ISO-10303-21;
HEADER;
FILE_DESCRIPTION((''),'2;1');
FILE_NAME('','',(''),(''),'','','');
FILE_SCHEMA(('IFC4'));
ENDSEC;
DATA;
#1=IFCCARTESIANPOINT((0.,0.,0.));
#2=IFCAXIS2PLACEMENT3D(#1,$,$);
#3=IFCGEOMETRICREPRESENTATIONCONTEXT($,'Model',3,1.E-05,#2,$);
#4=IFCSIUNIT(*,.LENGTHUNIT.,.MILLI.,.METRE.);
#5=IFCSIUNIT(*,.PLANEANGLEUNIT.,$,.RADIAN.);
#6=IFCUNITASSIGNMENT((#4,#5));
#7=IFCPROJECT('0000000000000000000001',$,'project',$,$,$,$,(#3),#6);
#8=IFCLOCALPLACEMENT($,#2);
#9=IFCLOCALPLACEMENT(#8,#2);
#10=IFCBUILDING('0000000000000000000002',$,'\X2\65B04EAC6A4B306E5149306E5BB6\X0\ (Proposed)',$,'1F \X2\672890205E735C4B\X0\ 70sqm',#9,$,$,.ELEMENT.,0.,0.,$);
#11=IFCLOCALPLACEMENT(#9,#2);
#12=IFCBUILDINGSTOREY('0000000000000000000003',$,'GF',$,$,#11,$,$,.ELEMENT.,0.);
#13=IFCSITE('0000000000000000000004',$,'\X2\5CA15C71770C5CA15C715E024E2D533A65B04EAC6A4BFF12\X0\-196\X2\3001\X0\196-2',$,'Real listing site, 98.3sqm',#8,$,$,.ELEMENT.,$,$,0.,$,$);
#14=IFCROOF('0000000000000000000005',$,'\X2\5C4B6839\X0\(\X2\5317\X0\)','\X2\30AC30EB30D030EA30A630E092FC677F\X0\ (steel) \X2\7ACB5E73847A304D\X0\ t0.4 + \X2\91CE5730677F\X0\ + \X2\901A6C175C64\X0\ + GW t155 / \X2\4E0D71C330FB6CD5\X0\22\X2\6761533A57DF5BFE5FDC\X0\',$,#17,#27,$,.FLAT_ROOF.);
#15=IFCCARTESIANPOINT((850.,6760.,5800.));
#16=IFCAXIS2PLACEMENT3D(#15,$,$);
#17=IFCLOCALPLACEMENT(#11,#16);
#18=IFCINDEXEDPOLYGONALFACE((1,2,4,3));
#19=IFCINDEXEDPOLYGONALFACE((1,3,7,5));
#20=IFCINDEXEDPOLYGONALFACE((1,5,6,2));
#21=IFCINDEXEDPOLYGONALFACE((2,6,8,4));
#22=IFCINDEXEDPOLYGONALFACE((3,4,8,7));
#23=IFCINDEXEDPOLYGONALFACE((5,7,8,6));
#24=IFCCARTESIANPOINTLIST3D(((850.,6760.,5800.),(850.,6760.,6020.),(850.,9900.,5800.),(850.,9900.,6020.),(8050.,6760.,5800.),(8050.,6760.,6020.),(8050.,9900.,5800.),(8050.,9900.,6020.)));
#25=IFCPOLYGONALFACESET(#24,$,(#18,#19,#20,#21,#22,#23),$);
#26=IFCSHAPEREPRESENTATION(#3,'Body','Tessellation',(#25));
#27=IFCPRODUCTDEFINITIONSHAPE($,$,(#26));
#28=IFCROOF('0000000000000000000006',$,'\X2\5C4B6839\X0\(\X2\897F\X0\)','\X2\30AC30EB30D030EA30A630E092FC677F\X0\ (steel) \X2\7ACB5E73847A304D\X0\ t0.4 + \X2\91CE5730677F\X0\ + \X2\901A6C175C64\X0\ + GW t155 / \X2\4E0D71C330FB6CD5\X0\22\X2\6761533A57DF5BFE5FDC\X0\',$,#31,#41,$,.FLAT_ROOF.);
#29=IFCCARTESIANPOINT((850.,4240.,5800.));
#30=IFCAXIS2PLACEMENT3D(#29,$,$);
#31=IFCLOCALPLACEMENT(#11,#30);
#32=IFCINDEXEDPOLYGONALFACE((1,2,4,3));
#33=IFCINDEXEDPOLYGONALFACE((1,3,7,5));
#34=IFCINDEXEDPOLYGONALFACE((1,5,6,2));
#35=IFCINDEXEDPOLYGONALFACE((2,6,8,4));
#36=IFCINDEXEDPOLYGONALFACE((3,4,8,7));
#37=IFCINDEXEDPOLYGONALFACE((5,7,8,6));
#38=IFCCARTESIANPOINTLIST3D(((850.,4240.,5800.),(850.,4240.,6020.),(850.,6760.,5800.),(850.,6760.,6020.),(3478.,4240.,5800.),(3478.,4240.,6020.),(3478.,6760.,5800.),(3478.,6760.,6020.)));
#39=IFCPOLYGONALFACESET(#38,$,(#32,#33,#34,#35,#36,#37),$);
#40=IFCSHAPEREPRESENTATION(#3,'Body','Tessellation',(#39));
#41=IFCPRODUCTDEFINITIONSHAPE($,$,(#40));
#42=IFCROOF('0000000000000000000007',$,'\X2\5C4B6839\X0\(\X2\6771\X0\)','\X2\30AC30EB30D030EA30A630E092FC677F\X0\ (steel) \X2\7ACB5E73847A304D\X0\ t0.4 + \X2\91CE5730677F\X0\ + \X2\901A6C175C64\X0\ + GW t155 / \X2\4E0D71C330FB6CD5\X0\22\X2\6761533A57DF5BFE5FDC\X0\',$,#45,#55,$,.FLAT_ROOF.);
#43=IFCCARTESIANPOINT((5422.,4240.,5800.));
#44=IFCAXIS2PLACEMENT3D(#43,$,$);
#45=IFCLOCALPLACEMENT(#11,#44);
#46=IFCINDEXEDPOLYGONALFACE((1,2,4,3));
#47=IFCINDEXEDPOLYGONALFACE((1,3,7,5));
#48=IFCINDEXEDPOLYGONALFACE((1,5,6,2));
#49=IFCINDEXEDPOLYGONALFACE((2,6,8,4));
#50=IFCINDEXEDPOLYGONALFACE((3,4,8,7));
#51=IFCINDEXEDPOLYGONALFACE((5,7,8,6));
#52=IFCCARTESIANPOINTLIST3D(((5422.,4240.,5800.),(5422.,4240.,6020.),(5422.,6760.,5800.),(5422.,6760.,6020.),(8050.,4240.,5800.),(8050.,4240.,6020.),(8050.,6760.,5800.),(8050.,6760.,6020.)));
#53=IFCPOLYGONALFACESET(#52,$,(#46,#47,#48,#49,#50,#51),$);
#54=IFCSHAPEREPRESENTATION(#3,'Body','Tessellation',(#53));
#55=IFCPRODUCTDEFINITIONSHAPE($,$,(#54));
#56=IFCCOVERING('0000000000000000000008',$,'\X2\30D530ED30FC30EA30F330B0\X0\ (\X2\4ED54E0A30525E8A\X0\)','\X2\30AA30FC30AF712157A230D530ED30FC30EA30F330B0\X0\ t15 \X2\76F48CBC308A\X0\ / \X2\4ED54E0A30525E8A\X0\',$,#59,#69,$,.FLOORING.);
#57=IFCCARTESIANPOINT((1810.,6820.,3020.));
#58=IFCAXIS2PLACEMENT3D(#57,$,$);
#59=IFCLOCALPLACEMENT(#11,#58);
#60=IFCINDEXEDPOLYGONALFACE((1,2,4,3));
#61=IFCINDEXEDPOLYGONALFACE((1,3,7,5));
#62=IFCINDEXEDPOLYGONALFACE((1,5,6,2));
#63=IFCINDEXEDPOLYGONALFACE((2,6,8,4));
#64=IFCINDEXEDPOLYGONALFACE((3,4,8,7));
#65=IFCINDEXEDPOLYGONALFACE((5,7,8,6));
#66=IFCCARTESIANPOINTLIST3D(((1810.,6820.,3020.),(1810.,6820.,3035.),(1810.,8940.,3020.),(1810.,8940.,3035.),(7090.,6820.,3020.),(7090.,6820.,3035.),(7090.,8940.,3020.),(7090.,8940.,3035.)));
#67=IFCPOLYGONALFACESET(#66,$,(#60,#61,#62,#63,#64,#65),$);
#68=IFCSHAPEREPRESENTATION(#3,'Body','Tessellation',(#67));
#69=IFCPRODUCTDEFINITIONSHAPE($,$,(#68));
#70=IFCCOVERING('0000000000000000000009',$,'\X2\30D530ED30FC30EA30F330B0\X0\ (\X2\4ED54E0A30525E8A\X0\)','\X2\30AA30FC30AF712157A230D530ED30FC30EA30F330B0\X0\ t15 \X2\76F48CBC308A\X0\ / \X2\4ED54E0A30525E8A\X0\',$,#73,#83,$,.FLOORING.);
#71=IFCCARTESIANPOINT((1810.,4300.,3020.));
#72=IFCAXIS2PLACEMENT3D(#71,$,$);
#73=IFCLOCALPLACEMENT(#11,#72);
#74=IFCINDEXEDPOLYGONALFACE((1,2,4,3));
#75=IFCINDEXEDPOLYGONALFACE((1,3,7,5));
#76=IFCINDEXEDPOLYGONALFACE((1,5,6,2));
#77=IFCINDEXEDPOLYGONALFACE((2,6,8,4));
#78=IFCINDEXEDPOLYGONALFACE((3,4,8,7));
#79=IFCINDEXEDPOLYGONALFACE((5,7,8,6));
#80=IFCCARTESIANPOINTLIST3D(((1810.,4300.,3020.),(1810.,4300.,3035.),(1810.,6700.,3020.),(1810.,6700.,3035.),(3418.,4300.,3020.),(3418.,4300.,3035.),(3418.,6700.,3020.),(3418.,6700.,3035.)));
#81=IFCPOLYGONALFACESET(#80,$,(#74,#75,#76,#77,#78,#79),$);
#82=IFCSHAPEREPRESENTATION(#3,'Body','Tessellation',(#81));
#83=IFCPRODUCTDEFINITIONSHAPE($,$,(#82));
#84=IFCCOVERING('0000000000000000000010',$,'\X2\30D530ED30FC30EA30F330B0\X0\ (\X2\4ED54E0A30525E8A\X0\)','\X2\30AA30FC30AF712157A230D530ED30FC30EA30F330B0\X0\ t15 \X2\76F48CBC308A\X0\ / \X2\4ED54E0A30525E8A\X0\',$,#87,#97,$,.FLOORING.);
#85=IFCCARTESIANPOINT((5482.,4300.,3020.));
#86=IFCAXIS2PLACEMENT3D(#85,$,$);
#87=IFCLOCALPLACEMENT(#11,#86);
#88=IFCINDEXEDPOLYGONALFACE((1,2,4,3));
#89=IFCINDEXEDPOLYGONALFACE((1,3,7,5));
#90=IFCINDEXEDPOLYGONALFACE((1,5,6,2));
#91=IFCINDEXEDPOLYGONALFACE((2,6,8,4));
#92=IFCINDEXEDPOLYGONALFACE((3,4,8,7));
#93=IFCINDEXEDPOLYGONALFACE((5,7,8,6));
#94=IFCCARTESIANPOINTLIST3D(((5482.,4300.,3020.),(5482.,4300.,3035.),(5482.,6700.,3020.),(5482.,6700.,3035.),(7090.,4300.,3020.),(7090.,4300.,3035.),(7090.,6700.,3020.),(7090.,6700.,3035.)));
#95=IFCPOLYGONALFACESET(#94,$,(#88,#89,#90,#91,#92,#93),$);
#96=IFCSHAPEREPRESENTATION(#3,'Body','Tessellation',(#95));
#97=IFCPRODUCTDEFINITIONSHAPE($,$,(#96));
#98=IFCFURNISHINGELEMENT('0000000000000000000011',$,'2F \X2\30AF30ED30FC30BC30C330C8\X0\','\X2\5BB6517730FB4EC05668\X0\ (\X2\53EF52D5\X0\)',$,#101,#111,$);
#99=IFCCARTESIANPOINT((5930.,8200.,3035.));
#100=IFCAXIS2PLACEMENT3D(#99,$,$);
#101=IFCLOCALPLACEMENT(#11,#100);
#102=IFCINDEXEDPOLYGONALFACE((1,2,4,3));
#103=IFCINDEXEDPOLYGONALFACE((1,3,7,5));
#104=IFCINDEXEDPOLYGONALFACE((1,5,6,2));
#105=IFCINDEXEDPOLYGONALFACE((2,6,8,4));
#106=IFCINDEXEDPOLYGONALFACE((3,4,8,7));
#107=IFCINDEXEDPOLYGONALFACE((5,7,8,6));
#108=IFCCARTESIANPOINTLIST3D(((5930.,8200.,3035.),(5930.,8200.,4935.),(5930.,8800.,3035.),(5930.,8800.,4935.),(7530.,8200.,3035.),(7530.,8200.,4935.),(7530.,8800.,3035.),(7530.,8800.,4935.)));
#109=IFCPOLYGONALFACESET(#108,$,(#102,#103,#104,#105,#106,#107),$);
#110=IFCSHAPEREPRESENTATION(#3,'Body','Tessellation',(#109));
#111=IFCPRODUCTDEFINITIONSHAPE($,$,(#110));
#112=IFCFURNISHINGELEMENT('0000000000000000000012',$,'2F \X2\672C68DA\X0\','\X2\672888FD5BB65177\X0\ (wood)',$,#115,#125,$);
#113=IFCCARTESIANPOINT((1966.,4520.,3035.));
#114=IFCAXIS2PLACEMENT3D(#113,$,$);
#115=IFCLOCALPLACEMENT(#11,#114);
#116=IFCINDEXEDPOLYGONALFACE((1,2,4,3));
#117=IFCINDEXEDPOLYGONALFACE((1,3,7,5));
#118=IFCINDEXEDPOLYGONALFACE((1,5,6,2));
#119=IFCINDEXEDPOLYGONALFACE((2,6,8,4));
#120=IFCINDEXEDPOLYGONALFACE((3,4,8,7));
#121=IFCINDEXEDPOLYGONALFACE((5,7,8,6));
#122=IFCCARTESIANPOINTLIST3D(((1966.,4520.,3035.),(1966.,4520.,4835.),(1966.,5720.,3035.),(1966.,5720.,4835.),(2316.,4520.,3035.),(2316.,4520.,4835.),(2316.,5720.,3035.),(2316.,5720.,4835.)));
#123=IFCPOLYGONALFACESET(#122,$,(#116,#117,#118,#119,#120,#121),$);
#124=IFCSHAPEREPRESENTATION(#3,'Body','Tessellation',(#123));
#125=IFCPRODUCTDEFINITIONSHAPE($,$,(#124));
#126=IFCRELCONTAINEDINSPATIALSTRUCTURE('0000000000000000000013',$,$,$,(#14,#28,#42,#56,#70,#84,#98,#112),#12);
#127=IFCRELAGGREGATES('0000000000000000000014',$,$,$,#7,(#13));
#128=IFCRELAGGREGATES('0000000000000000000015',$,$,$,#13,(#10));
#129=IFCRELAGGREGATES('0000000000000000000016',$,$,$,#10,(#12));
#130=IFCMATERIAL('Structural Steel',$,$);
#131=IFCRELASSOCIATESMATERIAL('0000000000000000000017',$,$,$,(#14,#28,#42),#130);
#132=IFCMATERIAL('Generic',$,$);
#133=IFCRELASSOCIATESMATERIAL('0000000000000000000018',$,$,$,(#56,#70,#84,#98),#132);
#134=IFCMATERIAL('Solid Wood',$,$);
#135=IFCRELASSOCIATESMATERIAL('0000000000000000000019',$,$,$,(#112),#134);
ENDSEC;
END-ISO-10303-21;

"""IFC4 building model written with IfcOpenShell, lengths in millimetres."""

from ifc_helpers import new_model, si_unit, frame, frame_2d, origin, place, context, project, spatial, rectangle, extrude, material, element, save


model = new_model("IFC4")

# Units and contexts
model_context = context("Model", 3, precision=1e-05, world=origin())
ifc_project = project(units=[si_unit("LENGTHUNIT", "METRE", prefix="MILLI"), si_unit("PLANEANGLEUNIT", "RADIAN")], contexts=[model_context])

# Site, building, storey
site_placement = place(None, origin())
site = spatial("IfcSite", under=ifc_project, at=site_placement, Name="岡山県岡山市中区新京橋２-196、196-2", ObjectType="Real listing site, 98.3sqm", CompositionType="ELEMENT", RefElevation=0.0)
building_placement = place(site_placement, origin())
building = spatial("IfcBuilding", under=site, at=building_placement, Name="新京橋の光の家 (Proposed)", ObjectType="1F 木造平屋 70sqm", CompositionType="ELEMENT", ElevationOfRefHeight=0.0, ElevationOfTerrain=0.0)
storey_placement = place(building_placement, origin())
storey = spatial("IfcBuildingStorey", under=building, at=storey_placement, Name="GF", CompositionType="ELEMENT", Elevation=0.0)

# Shared definitions
ifc_material_1 = material(Name="Solid Wood")

# Shared definitions
ifc_material_2 = material(Name="Generic")

# Roofs
ifc_material_3 = material(Name="Structural Steel")
for number, where, name in (
    (1, (850.0, 6760.0, 5800.0), "屋根(北)"),
):
    element("IfcRoof", number, at=place(storey_placement, frame(where)), inside=storey, material=ifc_material_3, Name=name, Description="ガルバリウム鋼板 (steel) 立平葺き t0.4 + 野地板 + 通気層 + GW t155 / 不燃・法22条区域対応", PredefinedType="FLAT_ROOF", context=model_context, shape_type="SweptSolid", body=[
        extrude(rectangle(XDim=7200.0, YDim=3140.0, at=frame_2d((3600.0, 1570.0))), frame((850.0, 6760.0, 5800.0)), (0.0, 0.0, 1.0), 220.0),
    ])
roof_1_placement = place(storey_placement, frame((850.0, 4240.0, 5800.0)))
element("IfcRoof", 2, at=roof_1_placement, inside=storey, material=ifc_material_3, Name="屋根(西)", Description="ガルバリウム鋼板 (steel) 立平葺き t0.4 + 野地板 + 通気層 + GW t155 / 不燃・法22条区域対応", PredefinedType="FLAT_ROOF", context=model_context, shape_type="SweptSolid", body=[
    extrude(rectangle(XDim=2628.0, YDim=2520.0, at=frame_2d((1314.0, 1260.0))), frame((850.0, 4240.0, 5800.0)), (0.0, 0.0, 1.0), 220.0),
])
roof_2_placement = place(storey_placement, frame((5422.0, 4240.0, 5800.0)))
element("IfcRoof", 3, at=roof_2_placement, inside=storey, material=ifc_material_3, Name="屋根(東)", Description="ガルバリウム鋼板 (steel) 立平葺き t0.4 + 野地板 + 通気層 + GW t155 / 不燃・法22条区域対応", PredefinedType="FLAT_ROOF", context=model_context, shape_type="SweptSolid", body=[
    extrude(rectangle(XDim=2628.0, YDim=2520.0, at=frame_2d((1314.0, 1260.0))), frame((5422.0, 4240.0, 5800.0)), (0.0, 0.0, 1.0), 220.0),
])

# Coverings
covering_1_placement = place(storey_placement, frame((1810.0, 6820.0, 3020.0)))
element("IfcCovering", 4, at=covering_1_placement, inside=storey, material=ifc_material_2, Name="フローリング (仕上げ床)", Description="オーク無垢フローリング t15 直貼り / 仕上げ床", PredefinedType="FLOORING", context=model_context, shape_type="SweptSolid", body=[
    extrude(rectangle(XDim=5280.0, YDim=2120.0, at=frame_2d((2640.0, 1060.0))), frame((1810.0, 6820.0, 3020.0)), (0.0, 0.0, 1.0), 15.0),
])
covering_2_placement = place(storey_placement, frame((1810.0, 4300.0, 3020.0)))
element("IfcCovering", 5, at=covering_2_placement, inside=storey, material=ifc_material_2, Name="フローリング (仕上げ床)", Description="オーク無垢フローリング t15 直貼り / 仕上げ床", PredefinedType="FLOORING", context=model_context, shape_type="SweptSolid", body=[
    extrude(rectangle(XDim=1608.0, YDim=2400.0, at=frame_2d((804.0, 1200.0))), frame((1810.0, 4300.0, 3020.0)), (0.0, 0.0, 1.0), 15.0),
])
covering_3_placement = place(storey_placement, frame((5482.0, 4300.0, 3020.0)))
element("IfcCovering", 6, at=covering_3_placement, inside=storey, material=ifc_material_2, Name="フローリング (仕上げ床)", Description="オーク無垢フローリング t15 直貼り / 仕上げ床", PredefinedType="FLOORING", context=model_context, shape_type="SweptSolid", body=[
    extrude(rectangle(XDim=1608.0, YDim=2400.0, at=frame_2d((804.0, 1200.0))), frame((5482.0, 4300.0, 3020.0)), (0.0, 0.0, 1.0), 15.0),
])

# Furnishing elements
furnishing_1_placement = place(storey_placement, frame((5930.0, 8200.0, 3035.0)))
element("IfcFurnishingElement", 7, at=furnishing_1_placement, inside=storey, material=ifc_material_2, Name="2F クローゼット", Description="家具・什器 (可動)", context=model_context, shape_type="SweptSolid", body=[
    extrude(rectangle(XDim=1600.0, YDim=600.0, at=frame_2d((800.0, 300.0))), frame((5930.0, 8200.0, 3035.0)), (0.0, 0.0, 1.0), 1900.0),
])
furnishing_2_placement = place(storey_placement, frame((1966.0, 4520.0, 3035.0)))
element("IfcFurnishingElement", 8, at=furnishing_2_placement, inside=storey, material=ifc_material_1, Name="2F 本棚", Description="木製家具 (wood)", context=model_context, shape_type="SweptSolid", body=[
    extrude(rectangle(XDim=350.0, YDim=1200.0, at=frame_2d((175.0, 600.0))), frame((1966.0, 4520.0, 3035.0)), (0.0, 0.0, 1.0), 1800.0),
])

save(model, "model.ifc")
